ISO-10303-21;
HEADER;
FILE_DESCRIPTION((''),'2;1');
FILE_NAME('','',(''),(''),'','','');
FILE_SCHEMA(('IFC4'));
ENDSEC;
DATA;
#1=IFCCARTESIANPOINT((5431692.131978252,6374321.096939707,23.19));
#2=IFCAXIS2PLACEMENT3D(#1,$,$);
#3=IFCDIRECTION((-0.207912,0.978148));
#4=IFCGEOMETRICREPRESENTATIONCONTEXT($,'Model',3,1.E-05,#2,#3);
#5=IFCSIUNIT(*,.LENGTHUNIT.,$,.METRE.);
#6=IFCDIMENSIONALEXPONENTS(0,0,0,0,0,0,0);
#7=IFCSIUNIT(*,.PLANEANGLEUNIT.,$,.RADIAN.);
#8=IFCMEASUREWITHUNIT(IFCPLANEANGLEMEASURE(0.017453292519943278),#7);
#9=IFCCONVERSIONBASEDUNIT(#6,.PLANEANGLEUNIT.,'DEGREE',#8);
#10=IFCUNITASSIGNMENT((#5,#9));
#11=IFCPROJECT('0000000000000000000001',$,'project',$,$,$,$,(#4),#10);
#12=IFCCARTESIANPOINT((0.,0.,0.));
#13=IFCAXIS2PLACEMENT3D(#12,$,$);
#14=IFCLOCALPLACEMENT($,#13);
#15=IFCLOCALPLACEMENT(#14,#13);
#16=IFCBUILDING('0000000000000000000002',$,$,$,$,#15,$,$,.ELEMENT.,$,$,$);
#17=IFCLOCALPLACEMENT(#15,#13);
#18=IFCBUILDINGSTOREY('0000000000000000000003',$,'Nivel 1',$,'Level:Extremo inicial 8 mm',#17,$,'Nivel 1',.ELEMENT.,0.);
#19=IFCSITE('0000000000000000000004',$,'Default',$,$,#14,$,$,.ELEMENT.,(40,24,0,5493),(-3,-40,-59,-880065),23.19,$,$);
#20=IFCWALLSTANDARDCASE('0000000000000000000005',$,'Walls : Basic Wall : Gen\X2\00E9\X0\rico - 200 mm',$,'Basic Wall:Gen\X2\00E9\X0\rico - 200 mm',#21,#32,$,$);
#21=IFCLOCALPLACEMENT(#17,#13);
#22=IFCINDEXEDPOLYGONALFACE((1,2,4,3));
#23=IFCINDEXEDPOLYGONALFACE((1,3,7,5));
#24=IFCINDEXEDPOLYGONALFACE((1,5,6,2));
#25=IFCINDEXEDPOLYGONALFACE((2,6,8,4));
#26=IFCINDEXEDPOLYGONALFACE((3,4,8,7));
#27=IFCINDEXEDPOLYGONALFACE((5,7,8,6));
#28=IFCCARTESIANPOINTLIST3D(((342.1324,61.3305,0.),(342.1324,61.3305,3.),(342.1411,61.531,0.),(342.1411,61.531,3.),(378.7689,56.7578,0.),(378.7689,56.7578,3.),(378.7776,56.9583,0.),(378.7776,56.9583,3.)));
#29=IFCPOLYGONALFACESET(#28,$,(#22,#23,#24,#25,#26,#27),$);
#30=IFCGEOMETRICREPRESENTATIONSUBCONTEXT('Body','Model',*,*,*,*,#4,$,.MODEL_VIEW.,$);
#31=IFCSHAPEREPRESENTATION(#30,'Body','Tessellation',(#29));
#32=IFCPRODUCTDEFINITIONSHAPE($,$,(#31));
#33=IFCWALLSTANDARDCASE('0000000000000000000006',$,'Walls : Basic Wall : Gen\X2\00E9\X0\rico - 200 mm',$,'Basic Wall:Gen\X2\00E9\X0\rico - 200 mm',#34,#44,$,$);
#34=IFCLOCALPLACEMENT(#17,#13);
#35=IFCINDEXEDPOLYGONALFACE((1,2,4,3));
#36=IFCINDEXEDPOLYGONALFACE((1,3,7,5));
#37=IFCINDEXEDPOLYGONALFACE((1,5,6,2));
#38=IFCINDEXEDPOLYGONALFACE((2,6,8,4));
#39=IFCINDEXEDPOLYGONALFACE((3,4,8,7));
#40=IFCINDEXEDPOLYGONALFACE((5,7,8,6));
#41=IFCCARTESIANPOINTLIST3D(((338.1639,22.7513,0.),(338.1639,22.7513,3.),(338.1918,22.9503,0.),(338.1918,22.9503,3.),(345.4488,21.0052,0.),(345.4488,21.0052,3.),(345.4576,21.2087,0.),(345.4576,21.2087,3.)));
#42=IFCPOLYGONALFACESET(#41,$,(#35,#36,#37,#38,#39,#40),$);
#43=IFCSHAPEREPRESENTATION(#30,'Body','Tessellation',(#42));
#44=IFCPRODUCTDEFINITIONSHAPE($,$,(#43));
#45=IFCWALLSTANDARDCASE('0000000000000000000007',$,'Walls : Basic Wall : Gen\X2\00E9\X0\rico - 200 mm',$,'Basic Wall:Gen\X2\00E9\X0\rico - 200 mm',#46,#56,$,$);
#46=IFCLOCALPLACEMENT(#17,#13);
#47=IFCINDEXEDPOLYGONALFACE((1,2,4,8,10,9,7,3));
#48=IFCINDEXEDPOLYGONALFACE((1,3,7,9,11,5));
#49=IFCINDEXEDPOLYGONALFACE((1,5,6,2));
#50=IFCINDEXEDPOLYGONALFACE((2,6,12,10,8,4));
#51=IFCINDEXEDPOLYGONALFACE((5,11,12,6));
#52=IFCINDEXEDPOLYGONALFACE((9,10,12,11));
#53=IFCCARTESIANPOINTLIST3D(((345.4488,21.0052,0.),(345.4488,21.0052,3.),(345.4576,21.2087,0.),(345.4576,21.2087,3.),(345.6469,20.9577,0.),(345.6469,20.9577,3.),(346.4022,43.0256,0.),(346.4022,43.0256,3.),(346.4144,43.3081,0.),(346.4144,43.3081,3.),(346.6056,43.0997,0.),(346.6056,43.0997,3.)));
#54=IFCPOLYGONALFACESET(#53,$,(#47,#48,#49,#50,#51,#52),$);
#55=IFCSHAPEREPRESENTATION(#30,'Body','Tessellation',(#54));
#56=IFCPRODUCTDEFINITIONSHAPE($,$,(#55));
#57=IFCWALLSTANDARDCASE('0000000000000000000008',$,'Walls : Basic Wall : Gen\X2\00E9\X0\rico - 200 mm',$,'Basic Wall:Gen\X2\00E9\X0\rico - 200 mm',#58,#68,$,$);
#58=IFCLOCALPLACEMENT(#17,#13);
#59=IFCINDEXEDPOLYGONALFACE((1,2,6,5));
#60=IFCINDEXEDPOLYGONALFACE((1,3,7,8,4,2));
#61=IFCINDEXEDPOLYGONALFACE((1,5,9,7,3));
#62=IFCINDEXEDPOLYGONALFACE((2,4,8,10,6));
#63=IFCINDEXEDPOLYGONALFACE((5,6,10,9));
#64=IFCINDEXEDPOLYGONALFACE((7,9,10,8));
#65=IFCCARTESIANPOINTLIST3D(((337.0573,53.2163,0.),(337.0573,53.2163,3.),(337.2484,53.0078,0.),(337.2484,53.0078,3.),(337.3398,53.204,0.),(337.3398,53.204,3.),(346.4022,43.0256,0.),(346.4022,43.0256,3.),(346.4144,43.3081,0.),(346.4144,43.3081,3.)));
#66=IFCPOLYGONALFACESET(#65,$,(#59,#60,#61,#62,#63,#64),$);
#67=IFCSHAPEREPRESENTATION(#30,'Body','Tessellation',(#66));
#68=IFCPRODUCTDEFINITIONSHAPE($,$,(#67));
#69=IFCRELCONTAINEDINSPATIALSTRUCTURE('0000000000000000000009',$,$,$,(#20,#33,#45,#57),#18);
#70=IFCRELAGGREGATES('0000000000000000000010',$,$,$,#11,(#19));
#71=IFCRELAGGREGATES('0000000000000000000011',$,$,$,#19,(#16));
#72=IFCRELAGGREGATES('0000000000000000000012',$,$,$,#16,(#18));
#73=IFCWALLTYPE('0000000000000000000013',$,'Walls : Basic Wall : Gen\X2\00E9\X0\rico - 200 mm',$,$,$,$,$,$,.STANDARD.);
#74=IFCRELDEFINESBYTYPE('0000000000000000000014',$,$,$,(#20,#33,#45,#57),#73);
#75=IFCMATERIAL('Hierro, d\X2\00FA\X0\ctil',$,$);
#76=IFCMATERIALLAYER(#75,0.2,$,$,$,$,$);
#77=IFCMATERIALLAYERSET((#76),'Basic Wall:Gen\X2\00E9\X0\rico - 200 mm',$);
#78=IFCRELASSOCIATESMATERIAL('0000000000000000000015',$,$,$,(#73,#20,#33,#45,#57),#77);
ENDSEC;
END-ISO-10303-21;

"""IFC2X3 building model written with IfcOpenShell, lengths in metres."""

from ifc_helpers import new_model, entity, si_unit, converted_unit, direction, frame, origin, place, context, subcontext, project, spatial, polyline, outline, extrude, material, layer, layer_set, layer_usage, type_object, element, save


model = new_model("IFC2X3")

# Units and contexts
model_context = context("Model", 3, precision=1e-05, world=frame((5431692.131978252, 6374321.096939707, 23.19)), true_north=direction((-0.207912, 0.978148)))
body_context = subcontext(model_context, "Body", "Model", "MODEL_VIEW")
ifc_project = project(units=[si_unit("LENGTHUNIT", "METRE"), converted_unit("PLANEANGLEUNIT", "DEGREE", entity("IfcPlaneAngleMeasure", 0.017453292519943278), si_unit("PLANEANGLEUNIT", "RADIAN"), dimensions=[0, 0, 0, 0, 0, 0, 0])], contexts=[model_context])

# Site, building, storey
site_placement = place(None, origin())
site = spatial("IfcSite", under=ifc_project, at=site_placement, Name="Default", CompositionType="ELEMENT", RefLatitude=(40, 24, 0, 5493), RefLongitude=(-3, -40, -59, -880065), RefElevation=23.19)
building_placement = place(site_placement, origin())
building = spatial("IfcBuilding", under=site, at=building_placement, CompositionType="ELEMENT")
storey_placement = place(building_placement, origin())
storey = spatial("IfcBuildingStorey", under=building, at=storey_placement, Name="Nivel 1", ObjectType="Level:Extremo inicial 8 mm", LongName="Nivel 1", CompositionType="ELEMENT", Elevation=0.0)

# Shared definitions
ifc_material_1 = material(Name="Hierro, dúctil")
ifc_layer_1 = layer(ifc_material_1, 0.2)
ifc_layer_set_1 = layer_set([ifc_layer_1], Name="Basic Wall:Genérico - 200 mm")
wall_type = type_object("IfcWallType", Name="Walls : Basic Wall : Genérico - 200 mm", PredefinedType="STANDARD", material=ifc_layer_set_1)

# Walls
ifc_layer_usage_1 = layer_usage(ifc_layer_set_1, "AXIS2", "NEGATIVE", 0.1)
wall_1_placement = place(storey_placement, frame((342.1287, 61.4318, 0.0), z_axis=(0.0, 0.0, 1.0), x_axis=(0.992301, -0.123853, 0.0)))
element("IfcWallStandardCase", 1, at=wall_1_placement, inside=storey, type_object=wall_type, material=ifc_layer_usage_1, Name="Walls : Basic Wall : Genérico - 200 mm", ObjectType="Basic Wall:Genérico - 200 mm", context=body_context, shape_type="SweptSolid", body=[
    extrude(outline(polyline([(36.937, -0.1), (36.9208, 0.1), (0.0, 0.1), (0.0162, -0.1), (36.937, -0.1)])), origin(), (0.0, 0.0, 1.0), 3.0),
])
ifc_layer_usage_2 = layer_usage(ifc_layer_set_1, "AXIS2", "NEGATIVE", 0.1)
wall_2_placement = place(storey_placement, frame((345.4721, 21.1024, 0.0), z_axis=(0.0, 0.0, 1.0), x_axis=(-0.972455, 0.23309, 0.0)))
element("IfcWallStandardCase", 2, at=wall_2_placement, inside=storey, type_object=wall_type, material=ifc_layer_usage_2, Name="Walls : Basic Wall : Genérico - 200 mm", ObjectType="Basic Wall:Genérico - 200 mm", context=body_context, shape_type="SweptSolid", body=[
    extrude(outline(polyline([(7.5105, -0.1), (7.4913, 0.1), (0.0, 0.1), (0.0389, -0.1), (7.5105, -0.1)])), origin(), (0.0, 0.0, 1.0), 3.0),
])
ifc_layer_usage_3 = layer_usage(ifc_layer_set_1, "AXIS2", "NEGATIVE", 0.1)
wall_3_placement = place(storey_placement, frame((345.547, 20.962, 0.0), z_axis=(0.0, 0.0, 1.0), x_axis=(0.043255, 0.999064, 0.0)))
element("IfcWallStandardCase", 3, at=wall_3_placement, inside=storey, type_object=wall_type, material=ifc_layer_usage_3, Name="Walls : Basic Wall : Genérico - 200 mm", ObjectType="Basic Wall:Genérico - 200 mm", context=body_context, shape_type="SweptSolid", body=[
    extrude(outline(polyline([(22.1627, -0.1), (22.3627, 0.1), (22.0799, 0.1), (0.2426, 0.1), (0.0389, 0.1), (0.0, -0.1), (22.1627, -0.1)])), origin(), (0.0, 0.0, 1.0), 3.0),
])
ifc_layer_usage_4 = layer_usage(ifc_layer_set_1, "AXIS2", "NEGATIVE", 0.1)
wall_4_placement = place(storey_placement, frame((346.4759, 43.0931, 0.0), z_axis=(0.0, 0.0, 1.0), x_axis=(-0.675859, 0.737031, 0.0)))
element("IfcWallStandardCase", 4, at=wall_4_placement, inside=storey, type_object=wall_type, material=ifc_layer_usage_4, Name="Walls : Basic Wall : Genérico - 200 mm", ObjectType="Basic Wall:Genérico - 200 mm", context=body_context, shape_type="SweptSolid", body=[
    extrude(outline(polyline([(13.6267, -0.1), (13.8267, 0.1), (13.5439, 0.1), (0.0, 0.1), (0.2, -0.1), (13.6267, -0.1)])), origin(), (0.0, 0.0, 1.0), 3.0),
])

save(model, "model.ifc")
